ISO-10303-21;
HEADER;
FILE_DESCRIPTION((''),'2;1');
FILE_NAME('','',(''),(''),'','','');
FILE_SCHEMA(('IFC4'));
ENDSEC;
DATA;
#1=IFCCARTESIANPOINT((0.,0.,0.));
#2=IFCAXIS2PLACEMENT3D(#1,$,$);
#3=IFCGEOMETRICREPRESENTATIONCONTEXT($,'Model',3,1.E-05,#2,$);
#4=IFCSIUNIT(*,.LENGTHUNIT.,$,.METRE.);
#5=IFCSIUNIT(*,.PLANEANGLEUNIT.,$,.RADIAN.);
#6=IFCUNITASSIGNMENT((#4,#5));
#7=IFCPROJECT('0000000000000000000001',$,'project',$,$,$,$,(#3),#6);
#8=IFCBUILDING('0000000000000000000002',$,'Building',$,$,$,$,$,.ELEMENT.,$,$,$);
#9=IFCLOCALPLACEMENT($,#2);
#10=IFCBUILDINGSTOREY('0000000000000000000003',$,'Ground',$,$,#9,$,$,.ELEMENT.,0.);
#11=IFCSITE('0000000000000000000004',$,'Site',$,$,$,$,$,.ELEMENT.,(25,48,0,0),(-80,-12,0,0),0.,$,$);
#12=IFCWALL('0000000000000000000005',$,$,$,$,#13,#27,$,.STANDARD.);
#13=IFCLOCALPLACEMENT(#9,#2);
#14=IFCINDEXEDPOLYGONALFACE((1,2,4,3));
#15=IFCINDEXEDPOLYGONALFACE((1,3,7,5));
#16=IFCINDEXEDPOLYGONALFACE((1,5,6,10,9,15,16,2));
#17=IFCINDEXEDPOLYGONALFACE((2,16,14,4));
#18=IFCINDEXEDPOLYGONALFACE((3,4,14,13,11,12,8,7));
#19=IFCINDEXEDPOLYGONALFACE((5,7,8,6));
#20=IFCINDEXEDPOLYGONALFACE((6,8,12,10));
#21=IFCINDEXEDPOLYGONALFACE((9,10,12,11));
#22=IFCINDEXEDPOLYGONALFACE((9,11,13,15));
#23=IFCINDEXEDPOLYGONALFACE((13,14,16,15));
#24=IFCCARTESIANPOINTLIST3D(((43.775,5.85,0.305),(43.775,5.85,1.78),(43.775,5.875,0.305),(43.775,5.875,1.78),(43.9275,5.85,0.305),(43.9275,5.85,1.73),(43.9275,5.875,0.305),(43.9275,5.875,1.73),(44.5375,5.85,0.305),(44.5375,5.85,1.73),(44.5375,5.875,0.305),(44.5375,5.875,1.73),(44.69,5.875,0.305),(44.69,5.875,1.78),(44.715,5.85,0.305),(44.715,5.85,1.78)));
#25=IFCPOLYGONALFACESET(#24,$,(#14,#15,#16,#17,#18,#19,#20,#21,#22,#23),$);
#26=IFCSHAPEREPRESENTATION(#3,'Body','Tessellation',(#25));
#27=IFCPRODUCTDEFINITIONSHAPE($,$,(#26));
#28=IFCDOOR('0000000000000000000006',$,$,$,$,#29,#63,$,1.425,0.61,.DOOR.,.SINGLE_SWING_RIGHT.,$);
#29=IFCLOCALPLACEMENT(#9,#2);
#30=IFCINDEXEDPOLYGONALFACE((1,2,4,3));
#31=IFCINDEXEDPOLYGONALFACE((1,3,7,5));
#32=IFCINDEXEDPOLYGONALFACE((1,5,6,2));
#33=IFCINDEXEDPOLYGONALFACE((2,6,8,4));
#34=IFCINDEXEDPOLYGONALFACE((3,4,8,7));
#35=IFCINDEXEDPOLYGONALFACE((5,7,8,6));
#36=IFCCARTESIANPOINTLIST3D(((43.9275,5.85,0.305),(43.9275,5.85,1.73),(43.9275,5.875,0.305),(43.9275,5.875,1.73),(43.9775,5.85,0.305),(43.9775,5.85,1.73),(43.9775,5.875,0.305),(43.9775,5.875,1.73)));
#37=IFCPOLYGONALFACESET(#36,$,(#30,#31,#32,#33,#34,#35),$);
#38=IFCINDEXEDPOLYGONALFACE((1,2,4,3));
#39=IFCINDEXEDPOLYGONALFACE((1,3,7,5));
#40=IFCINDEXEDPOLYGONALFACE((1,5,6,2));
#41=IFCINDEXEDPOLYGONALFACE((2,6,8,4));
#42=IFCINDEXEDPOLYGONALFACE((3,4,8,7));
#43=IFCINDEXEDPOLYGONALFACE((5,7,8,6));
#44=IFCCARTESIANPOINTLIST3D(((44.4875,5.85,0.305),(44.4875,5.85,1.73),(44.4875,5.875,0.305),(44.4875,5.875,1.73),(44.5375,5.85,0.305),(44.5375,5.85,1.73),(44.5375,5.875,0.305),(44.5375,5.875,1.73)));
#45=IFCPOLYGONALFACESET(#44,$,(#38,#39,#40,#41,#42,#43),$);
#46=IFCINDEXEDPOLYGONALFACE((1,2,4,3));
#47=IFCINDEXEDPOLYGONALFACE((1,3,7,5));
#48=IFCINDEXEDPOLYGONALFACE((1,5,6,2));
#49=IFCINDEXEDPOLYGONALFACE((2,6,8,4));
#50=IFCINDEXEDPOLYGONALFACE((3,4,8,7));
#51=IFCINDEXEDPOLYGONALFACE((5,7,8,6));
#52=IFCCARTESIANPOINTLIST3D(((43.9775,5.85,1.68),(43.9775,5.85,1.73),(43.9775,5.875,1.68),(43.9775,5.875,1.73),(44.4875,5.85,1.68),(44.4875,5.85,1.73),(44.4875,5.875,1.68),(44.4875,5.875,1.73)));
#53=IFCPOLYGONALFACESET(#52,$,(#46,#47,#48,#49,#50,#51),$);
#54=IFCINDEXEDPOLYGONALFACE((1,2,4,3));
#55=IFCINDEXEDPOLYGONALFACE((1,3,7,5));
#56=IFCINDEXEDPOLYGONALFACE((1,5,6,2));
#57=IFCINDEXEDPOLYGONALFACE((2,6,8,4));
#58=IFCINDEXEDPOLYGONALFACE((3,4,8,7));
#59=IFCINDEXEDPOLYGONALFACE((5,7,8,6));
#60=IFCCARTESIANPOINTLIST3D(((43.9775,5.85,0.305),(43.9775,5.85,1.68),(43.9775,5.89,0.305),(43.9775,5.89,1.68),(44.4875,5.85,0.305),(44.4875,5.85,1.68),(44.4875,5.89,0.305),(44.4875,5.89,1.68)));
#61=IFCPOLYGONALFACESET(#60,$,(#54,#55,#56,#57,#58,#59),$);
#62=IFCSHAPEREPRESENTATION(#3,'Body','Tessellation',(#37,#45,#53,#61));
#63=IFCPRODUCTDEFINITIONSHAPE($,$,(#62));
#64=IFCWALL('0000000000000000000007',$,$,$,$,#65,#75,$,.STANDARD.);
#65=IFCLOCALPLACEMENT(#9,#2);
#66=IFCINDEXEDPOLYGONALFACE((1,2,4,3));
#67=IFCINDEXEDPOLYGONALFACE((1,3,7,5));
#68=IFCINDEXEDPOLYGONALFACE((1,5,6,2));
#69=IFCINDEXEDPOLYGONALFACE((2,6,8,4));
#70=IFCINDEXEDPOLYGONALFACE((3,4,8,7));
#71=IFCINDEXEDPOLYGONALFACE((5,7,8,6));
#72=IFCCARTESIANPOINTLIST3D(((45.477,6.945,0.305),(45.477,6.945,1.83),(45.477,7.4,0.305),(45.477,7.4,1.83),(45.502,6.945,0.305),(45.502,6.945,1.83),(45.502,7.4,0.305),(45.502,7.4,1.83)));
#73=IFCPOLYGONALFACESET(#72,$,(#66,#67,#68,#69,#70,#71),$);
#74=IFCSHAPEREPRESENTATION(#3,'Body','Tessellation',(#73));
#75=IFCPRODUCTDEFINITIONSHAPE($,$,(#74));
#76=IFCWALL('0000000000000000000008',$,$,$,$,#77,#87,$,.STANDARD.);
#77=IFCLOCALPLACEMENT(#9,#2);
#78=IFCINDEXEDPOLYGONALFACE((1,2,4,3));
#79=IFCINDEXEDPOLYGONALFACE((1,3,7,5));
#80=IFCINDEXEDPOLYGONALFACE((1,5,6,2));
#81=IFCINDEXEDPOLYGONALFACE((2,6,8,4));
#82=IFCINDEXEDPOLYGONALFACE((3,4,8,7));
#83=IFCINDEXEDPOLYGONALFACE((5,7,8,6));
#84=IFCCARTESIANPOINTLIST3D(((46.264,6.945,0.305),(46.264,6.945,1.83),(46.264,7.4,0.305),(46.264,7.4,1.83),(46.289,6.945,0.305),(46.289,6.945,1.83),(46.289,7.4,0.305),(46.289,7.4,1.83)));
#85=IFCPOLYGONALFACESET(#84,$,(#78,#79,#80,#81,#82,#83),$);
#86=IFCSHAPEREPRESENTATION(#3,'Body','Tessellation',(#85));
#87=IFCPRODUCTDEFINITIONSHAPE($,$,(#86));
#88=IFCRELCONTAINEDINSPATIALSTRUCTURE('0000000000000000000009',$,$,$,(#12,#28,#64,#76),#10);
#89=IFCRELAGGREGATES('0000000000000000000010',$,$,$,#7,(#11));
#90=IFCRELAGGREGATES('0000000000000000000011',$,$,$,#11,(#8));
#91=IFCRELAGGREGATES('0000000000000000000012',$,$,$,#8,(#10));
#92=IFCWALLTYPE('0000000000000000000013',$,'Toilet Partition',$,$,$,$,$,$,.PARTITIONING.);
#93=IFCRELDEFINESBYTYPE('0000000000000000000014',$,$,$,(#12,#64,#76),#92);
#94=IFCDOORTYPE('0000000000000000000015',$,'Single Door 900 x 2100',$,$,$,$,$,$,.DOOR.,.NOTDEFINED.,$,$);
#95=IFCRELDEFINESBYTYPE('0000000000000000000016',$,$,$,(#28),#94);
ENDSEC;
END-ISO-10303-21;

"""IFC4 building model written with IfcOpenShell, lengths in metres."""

from ifc_helpers import new_model, si_unit, frame, frame_2d, origin, origin_with_axes, origin_2d, place, context, project, spatial, polyline, rectangle, outline, extrude, type_object, element, fill, save


model = new_model("IFC4")

# Units and contexts
model_context = context("Model", 3, precision=1e-05, world=origin())
ifc_project = project(units=[si_unit("LENGTHUNIT", "METRE"), si_unit("PLANEANGLEUNIT", "RADIAN")], contexts=[model_context])

# Site, building, storey
site = spatial("IfcSite", under=ifc_project, Name="Site", CompositionType="ELEMENT", RefLatitude=(25, 48, 0, 0), RefLongitude=(-80, -12, 0, 0), RefElevation=0.0)
building = spatial("IfcBuilding", under=site, Name="Building", CompositionType="ELEMENT")
storey_placement = place(None, origin())
storey = spatial("IfcBuildingStorey", under=building, at=storey_placement, Name="Ground", CompositionType="ELEMENT", Elevation=0.0)

# Shared definitions
door_type = type_object("IfcDoorType", Name="Single Door 900 x 2100", OperationType="NOTDEFINED", PredefinedType="DOOR")

# Shared definitions
wall_type_1 = type_object("IfcWallType", Name="Toilet Partition", PredefinedType="PARTITIONING")

# Wall, opening, door
wall_1_placement = place(None, frame((43.775, 5.8625, 0.305), z_axis=(0.0, 0.0, 1.0), x_axis=(1.0, 0.0, 0.0)))
wall_1 = element("IfcWall", 1, at=wall_1_placement, inside=storey, type_object=wall_type_1, PredefinedType="STANDARD", context=model_context, shape_type="SweptSolid", body=[
    extrude(outline(polyline([(0.0, -0.0125), (0.94, -0.0125), (0.915, 0.0125), (0.0, 0.0125), (0.0, -0.0125)])), origin(), (0.0, 0.0, 1.0), 1.475),
])
opening_1_placement = place(wall_1_placement, frame((0.4575, 0.0, 0.0), z_axis=(0.0, 0.0, 1.0), x_axis=(1.0, 0.0, 0.0)))
opening_1 = element("IfcOpeningElement", 2, at=opening_1_placement, cuts=wall_1, PredefinedType="OPENING", context=model_context, shape_type="SweptSolid", body=[
    extrude(rectangle(XDim=0.61, YDim=0.027, at=origin_2d()), origin(), (0.0, 0.0, 1.0), 1.425),
])
door_1_placement = place(opening_1_placement, origin_with_axes())
door_1 = element("IfcDoor", 3, at=door_1_placement, inside=storey, type_object=door_type, OperationType="SINGLE_SWING_RIGHT", OverallHeight=1.425, OverallWidth=0.61, PredefinedType="DOOR", context=model_context, shape_type="SweptSolid", body=[
    extrude(rectangle(XDim=0.05, YDim=0.025, at=frame_2d((-0.28, 0.0))), origin(), (0.0, 0.0, 1.0), 1.425),
    extrude(rectangle(XDim=0.05, YDim=0.025, at=frame_2d((0.28, 0.0))), origin(), (0.0, 0.0, 1.0), 1.425),
    extrude(rectangle(XDim=0.51, YDim=0.025, at=origin_2d()), frame((0.0, 0.0, 1.375)), (0.0, 0.0, 1.0), 0.05),
    extrude(rectangle(XDim=0.51, YDim=0.04, at=frame_2d((0.0, 0.0075))), origin(), (0.0, 0.0, 1.0), 1.375),
])
fill(opening_1, door_1)

# Walls
for number, where, z_axis, x_axis in (
    (4, (45.4895, 7.4, 0.305), (0.0, 0.0, 1.0), (0.0, -1.0, 0.0)),
    (5, (46.2765, 7.4, 0.305), (0.0, 0.0, 1.0), (0.0, -1.0, 0.0)),
):
    element("IfcWall", number, at=place(None, frame(where, z_axis=z_axis, x_axis=x_axis)), inside=storey, type_object=wall_type_1, PredefinedType="STANDARD", context=model_context, shape_type="SweptSolid", body=[
        extrude(rectangle(XDim=0.455, YDim=0.025, at=frame_2d((0.2275, 0.0))), origin(), (0.0, 0.0, 1.0), 1.525),
    ])

save(model, "model.ifc")
